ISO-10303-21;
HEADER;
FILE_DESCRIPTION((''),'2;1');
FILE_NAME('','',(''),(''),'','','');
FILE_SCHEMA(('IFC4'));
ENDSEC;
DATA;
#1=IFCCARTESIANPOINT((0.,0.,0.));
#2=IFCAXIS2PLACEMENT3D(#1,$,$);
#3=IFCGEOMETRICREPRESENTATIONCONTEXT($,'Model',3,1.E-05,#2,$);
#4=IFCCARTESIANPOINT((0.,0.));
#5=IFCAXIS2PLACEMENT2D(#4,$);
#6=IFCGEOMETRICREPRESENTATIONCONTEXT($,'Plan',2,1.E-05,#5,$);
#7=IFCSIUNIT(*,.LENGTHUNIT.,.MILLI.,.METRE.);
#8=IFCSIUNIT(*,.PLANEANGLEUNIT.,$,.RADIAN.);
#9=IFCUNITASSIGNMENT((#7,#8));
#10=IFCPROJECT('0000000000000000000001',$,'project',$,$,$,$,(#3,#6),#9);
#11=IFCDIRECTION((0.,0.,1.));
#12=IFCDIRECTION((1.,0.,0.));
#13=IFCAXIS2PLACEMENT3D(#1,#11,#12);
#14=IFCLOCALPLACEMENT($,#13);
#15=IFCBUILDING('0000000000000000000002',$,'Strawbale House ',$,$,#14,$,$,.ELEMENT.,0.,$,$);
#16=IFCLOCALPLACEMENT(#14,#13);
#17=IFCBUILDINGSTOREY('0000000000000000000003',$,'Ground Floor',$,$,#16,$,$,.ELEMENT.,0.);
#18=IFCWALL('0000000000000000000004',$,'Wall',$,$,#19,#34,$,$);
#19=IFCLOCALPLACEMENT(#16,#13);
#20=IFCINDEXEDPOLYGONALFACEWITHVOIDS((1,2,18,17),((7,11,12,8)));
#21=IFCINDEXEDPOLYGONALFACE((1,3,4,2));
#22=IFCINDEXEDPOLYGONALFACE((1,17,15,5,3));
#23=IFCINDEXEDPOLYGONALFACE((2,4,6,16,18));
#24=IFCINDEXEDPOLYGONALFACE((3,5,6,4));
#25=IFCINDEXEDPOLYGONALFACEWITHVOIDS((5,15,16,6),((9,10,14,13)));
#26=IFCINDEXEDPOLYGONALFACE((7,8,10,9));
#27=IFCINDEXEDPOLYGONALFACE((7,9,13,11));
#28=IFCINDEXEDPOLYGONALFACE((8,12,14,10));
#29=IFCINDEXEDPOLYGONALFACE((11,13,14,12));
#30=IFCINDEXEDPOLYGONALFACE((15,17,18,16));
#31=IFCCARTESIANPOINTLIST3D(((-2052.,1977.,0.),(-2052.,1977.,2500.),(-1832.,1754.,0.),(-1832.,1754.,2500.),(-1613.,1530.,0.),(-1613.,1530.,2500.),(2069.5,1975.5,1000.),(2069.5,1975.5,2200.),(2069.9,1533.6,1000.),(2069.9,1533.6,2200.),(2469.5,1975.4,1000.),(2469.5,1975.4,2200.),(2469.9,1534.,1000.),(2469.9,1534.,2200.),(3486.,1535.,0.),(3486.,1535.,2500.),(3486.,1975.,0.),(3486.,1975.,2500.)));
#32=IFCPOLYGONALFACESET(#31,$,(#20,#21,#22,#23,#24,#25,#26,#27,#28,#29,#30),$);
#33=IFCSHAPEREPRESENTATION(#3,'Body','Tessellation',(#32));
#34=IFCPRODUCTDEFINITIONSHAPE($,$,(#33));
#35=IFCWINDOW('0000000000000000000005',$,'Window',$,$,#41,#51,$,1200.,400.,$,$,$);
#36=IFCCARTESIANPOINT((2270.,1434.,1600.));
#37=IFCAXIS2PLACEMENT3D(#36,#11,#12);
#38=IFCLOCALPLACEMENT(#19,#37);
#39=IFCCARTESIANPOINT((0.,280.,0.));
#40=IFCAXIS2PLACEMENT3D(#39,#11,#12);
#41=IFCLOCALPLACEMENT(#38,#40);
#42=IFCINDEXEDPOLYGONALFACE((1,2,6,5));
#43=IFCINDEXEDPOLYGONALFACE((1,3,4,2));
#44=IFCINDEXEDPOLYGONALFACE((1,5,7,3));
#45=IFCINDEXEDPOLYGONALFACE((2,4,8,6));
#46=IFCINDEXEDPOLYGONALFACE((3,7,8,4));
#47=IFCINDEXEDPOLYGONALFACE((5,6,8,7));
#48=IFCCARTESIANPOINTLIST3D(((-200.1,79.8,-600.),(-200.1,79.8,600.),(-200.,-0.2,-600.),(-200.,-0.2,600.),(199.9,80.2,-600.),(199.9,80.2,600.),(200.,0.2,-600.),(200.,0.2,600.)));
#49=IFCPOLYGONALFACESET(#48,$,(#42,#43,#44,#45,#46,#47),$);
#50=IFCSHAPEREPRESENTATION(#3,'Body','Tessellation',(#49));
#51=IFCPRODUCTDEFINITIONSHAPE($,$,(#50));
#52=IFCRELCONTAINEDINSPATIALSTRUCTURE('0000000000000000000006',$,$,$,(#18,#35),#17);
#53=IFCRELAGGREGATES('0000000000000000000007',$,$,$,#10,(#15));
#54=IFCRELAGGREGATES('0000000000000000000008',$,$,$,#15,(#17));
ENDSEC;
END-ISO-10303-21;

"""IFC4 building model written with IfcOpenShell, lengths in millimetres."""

from ifc_helpers import new_model, si_unit, frame, origin, origin_with_axes, origin_2d, origin_2d_with_axis, place, context, project, spatial, polyline, rectangle, outline, extrude, element, fill, save


model = new_model("IFC4")

# Units and contexts
model_context = context("Model", 3, precision=1e-05, world=origin())
plan_context = context("Plan", 2, precision=1e-05, world=origin_2d())
ifc_project = project(units=[si_unit("LENGTHUNIT", "METRE", prefix="MILLI"), si_unit("PLANEANGLEUNIT", "RADIAN")], contexts=[model_context, plan_context])

# Building, storey
building_placement = place(None, origin_with_axes())
building = spatial("IfcBuilding", under=ifc_project, at=building_placement, Name="Strawbale House ", CompositionType="ELEMENT", ElevationOfRefHeight=0.0)
storey_placement = place(building_placement, origin_with_axes())
storey = spatial("IfcBuildingStorey", under=building, at=storey_placement, Name="Ground Floor", CompositionType="ELEMENT", Elevation=0.0)

# Wall, opening, window
wall_1_placement = place(storey_placement, origin_with_axes())
wall_1 = element("IfcWall", 1, at=wall_1_placement, inside=storey, Name="Wall", context=model_context, shape_type="SweptSolid", body=[
    extrude(outline(polyline([(3486.0, 1755.0, 0.0), (3486.0, 1535.0, 0.0), (-1613.0, 1530.0, 0.0), (-1832.0, 1754.0, 0.0), (-2052.0, 1977.0, 0.0), (3486.0, 1975.0, 0.0), (3486.0, 1755.0, 0.0)])), origin_with_axes(), (0.0, 0.0, 1.0), 2500.0),
])
opening_1_placement = place(wall_1_placement, frame((2270.0, 1434.0, 1600.0), z_axis=(0.0, 0.0, 1.0), x_axis=(1.0, 0.0, 0.0)))
opening_1 = element("IfcOpeningElement", 2, at=opening_1_placement, cuts=wall_1, PredefinedType="OPENING", context=model_context, shape_type="SweptSolid", body=[
    extrude(rectangle(XDim=400.0, YDim=1200.0, at=origin_2d_with_axis()), frame((0.0, 0.0, 0.0), z_axis=(-5.0, 5099.0, 0.0), x_axis=(-5099.0, -5.0, 0.0)), (0.0, 0.0, 1.0), 639.7),
])
window_1_placement = place(opening_1_placement, frame((0.0, 280.0, 0.0), z_axis=(0.0, 0.0, 1.0), x_axis=(1.0, 0.0, 0.0)))
window_1 = element("IfcWindow", 3, at=window_1_placement, inside=storey, Name="Window", OverallHeight=1200.0, OverallWidth=400.0, context=model_context, shape_type="SweptSolid", body=[
    extrude(outline(polyline([(200.0, 600.0, 0.0), (200.0, -600.0, 0.0), (-200.0, -600.0, 0.0), (-200.0, 600.0, 0.0), (200.0, 600.0, 0.0)])), frame((0.0, 0.0, 0.0), z_axis=(-5.0, 5099.0, 0.0), x_axis=(-5099.0, -5.0, 0.0)), (0.0, 0.0, 1.0), 80.0),
])
fill(opening_1, window_1)

save(model, "model.ifc")
